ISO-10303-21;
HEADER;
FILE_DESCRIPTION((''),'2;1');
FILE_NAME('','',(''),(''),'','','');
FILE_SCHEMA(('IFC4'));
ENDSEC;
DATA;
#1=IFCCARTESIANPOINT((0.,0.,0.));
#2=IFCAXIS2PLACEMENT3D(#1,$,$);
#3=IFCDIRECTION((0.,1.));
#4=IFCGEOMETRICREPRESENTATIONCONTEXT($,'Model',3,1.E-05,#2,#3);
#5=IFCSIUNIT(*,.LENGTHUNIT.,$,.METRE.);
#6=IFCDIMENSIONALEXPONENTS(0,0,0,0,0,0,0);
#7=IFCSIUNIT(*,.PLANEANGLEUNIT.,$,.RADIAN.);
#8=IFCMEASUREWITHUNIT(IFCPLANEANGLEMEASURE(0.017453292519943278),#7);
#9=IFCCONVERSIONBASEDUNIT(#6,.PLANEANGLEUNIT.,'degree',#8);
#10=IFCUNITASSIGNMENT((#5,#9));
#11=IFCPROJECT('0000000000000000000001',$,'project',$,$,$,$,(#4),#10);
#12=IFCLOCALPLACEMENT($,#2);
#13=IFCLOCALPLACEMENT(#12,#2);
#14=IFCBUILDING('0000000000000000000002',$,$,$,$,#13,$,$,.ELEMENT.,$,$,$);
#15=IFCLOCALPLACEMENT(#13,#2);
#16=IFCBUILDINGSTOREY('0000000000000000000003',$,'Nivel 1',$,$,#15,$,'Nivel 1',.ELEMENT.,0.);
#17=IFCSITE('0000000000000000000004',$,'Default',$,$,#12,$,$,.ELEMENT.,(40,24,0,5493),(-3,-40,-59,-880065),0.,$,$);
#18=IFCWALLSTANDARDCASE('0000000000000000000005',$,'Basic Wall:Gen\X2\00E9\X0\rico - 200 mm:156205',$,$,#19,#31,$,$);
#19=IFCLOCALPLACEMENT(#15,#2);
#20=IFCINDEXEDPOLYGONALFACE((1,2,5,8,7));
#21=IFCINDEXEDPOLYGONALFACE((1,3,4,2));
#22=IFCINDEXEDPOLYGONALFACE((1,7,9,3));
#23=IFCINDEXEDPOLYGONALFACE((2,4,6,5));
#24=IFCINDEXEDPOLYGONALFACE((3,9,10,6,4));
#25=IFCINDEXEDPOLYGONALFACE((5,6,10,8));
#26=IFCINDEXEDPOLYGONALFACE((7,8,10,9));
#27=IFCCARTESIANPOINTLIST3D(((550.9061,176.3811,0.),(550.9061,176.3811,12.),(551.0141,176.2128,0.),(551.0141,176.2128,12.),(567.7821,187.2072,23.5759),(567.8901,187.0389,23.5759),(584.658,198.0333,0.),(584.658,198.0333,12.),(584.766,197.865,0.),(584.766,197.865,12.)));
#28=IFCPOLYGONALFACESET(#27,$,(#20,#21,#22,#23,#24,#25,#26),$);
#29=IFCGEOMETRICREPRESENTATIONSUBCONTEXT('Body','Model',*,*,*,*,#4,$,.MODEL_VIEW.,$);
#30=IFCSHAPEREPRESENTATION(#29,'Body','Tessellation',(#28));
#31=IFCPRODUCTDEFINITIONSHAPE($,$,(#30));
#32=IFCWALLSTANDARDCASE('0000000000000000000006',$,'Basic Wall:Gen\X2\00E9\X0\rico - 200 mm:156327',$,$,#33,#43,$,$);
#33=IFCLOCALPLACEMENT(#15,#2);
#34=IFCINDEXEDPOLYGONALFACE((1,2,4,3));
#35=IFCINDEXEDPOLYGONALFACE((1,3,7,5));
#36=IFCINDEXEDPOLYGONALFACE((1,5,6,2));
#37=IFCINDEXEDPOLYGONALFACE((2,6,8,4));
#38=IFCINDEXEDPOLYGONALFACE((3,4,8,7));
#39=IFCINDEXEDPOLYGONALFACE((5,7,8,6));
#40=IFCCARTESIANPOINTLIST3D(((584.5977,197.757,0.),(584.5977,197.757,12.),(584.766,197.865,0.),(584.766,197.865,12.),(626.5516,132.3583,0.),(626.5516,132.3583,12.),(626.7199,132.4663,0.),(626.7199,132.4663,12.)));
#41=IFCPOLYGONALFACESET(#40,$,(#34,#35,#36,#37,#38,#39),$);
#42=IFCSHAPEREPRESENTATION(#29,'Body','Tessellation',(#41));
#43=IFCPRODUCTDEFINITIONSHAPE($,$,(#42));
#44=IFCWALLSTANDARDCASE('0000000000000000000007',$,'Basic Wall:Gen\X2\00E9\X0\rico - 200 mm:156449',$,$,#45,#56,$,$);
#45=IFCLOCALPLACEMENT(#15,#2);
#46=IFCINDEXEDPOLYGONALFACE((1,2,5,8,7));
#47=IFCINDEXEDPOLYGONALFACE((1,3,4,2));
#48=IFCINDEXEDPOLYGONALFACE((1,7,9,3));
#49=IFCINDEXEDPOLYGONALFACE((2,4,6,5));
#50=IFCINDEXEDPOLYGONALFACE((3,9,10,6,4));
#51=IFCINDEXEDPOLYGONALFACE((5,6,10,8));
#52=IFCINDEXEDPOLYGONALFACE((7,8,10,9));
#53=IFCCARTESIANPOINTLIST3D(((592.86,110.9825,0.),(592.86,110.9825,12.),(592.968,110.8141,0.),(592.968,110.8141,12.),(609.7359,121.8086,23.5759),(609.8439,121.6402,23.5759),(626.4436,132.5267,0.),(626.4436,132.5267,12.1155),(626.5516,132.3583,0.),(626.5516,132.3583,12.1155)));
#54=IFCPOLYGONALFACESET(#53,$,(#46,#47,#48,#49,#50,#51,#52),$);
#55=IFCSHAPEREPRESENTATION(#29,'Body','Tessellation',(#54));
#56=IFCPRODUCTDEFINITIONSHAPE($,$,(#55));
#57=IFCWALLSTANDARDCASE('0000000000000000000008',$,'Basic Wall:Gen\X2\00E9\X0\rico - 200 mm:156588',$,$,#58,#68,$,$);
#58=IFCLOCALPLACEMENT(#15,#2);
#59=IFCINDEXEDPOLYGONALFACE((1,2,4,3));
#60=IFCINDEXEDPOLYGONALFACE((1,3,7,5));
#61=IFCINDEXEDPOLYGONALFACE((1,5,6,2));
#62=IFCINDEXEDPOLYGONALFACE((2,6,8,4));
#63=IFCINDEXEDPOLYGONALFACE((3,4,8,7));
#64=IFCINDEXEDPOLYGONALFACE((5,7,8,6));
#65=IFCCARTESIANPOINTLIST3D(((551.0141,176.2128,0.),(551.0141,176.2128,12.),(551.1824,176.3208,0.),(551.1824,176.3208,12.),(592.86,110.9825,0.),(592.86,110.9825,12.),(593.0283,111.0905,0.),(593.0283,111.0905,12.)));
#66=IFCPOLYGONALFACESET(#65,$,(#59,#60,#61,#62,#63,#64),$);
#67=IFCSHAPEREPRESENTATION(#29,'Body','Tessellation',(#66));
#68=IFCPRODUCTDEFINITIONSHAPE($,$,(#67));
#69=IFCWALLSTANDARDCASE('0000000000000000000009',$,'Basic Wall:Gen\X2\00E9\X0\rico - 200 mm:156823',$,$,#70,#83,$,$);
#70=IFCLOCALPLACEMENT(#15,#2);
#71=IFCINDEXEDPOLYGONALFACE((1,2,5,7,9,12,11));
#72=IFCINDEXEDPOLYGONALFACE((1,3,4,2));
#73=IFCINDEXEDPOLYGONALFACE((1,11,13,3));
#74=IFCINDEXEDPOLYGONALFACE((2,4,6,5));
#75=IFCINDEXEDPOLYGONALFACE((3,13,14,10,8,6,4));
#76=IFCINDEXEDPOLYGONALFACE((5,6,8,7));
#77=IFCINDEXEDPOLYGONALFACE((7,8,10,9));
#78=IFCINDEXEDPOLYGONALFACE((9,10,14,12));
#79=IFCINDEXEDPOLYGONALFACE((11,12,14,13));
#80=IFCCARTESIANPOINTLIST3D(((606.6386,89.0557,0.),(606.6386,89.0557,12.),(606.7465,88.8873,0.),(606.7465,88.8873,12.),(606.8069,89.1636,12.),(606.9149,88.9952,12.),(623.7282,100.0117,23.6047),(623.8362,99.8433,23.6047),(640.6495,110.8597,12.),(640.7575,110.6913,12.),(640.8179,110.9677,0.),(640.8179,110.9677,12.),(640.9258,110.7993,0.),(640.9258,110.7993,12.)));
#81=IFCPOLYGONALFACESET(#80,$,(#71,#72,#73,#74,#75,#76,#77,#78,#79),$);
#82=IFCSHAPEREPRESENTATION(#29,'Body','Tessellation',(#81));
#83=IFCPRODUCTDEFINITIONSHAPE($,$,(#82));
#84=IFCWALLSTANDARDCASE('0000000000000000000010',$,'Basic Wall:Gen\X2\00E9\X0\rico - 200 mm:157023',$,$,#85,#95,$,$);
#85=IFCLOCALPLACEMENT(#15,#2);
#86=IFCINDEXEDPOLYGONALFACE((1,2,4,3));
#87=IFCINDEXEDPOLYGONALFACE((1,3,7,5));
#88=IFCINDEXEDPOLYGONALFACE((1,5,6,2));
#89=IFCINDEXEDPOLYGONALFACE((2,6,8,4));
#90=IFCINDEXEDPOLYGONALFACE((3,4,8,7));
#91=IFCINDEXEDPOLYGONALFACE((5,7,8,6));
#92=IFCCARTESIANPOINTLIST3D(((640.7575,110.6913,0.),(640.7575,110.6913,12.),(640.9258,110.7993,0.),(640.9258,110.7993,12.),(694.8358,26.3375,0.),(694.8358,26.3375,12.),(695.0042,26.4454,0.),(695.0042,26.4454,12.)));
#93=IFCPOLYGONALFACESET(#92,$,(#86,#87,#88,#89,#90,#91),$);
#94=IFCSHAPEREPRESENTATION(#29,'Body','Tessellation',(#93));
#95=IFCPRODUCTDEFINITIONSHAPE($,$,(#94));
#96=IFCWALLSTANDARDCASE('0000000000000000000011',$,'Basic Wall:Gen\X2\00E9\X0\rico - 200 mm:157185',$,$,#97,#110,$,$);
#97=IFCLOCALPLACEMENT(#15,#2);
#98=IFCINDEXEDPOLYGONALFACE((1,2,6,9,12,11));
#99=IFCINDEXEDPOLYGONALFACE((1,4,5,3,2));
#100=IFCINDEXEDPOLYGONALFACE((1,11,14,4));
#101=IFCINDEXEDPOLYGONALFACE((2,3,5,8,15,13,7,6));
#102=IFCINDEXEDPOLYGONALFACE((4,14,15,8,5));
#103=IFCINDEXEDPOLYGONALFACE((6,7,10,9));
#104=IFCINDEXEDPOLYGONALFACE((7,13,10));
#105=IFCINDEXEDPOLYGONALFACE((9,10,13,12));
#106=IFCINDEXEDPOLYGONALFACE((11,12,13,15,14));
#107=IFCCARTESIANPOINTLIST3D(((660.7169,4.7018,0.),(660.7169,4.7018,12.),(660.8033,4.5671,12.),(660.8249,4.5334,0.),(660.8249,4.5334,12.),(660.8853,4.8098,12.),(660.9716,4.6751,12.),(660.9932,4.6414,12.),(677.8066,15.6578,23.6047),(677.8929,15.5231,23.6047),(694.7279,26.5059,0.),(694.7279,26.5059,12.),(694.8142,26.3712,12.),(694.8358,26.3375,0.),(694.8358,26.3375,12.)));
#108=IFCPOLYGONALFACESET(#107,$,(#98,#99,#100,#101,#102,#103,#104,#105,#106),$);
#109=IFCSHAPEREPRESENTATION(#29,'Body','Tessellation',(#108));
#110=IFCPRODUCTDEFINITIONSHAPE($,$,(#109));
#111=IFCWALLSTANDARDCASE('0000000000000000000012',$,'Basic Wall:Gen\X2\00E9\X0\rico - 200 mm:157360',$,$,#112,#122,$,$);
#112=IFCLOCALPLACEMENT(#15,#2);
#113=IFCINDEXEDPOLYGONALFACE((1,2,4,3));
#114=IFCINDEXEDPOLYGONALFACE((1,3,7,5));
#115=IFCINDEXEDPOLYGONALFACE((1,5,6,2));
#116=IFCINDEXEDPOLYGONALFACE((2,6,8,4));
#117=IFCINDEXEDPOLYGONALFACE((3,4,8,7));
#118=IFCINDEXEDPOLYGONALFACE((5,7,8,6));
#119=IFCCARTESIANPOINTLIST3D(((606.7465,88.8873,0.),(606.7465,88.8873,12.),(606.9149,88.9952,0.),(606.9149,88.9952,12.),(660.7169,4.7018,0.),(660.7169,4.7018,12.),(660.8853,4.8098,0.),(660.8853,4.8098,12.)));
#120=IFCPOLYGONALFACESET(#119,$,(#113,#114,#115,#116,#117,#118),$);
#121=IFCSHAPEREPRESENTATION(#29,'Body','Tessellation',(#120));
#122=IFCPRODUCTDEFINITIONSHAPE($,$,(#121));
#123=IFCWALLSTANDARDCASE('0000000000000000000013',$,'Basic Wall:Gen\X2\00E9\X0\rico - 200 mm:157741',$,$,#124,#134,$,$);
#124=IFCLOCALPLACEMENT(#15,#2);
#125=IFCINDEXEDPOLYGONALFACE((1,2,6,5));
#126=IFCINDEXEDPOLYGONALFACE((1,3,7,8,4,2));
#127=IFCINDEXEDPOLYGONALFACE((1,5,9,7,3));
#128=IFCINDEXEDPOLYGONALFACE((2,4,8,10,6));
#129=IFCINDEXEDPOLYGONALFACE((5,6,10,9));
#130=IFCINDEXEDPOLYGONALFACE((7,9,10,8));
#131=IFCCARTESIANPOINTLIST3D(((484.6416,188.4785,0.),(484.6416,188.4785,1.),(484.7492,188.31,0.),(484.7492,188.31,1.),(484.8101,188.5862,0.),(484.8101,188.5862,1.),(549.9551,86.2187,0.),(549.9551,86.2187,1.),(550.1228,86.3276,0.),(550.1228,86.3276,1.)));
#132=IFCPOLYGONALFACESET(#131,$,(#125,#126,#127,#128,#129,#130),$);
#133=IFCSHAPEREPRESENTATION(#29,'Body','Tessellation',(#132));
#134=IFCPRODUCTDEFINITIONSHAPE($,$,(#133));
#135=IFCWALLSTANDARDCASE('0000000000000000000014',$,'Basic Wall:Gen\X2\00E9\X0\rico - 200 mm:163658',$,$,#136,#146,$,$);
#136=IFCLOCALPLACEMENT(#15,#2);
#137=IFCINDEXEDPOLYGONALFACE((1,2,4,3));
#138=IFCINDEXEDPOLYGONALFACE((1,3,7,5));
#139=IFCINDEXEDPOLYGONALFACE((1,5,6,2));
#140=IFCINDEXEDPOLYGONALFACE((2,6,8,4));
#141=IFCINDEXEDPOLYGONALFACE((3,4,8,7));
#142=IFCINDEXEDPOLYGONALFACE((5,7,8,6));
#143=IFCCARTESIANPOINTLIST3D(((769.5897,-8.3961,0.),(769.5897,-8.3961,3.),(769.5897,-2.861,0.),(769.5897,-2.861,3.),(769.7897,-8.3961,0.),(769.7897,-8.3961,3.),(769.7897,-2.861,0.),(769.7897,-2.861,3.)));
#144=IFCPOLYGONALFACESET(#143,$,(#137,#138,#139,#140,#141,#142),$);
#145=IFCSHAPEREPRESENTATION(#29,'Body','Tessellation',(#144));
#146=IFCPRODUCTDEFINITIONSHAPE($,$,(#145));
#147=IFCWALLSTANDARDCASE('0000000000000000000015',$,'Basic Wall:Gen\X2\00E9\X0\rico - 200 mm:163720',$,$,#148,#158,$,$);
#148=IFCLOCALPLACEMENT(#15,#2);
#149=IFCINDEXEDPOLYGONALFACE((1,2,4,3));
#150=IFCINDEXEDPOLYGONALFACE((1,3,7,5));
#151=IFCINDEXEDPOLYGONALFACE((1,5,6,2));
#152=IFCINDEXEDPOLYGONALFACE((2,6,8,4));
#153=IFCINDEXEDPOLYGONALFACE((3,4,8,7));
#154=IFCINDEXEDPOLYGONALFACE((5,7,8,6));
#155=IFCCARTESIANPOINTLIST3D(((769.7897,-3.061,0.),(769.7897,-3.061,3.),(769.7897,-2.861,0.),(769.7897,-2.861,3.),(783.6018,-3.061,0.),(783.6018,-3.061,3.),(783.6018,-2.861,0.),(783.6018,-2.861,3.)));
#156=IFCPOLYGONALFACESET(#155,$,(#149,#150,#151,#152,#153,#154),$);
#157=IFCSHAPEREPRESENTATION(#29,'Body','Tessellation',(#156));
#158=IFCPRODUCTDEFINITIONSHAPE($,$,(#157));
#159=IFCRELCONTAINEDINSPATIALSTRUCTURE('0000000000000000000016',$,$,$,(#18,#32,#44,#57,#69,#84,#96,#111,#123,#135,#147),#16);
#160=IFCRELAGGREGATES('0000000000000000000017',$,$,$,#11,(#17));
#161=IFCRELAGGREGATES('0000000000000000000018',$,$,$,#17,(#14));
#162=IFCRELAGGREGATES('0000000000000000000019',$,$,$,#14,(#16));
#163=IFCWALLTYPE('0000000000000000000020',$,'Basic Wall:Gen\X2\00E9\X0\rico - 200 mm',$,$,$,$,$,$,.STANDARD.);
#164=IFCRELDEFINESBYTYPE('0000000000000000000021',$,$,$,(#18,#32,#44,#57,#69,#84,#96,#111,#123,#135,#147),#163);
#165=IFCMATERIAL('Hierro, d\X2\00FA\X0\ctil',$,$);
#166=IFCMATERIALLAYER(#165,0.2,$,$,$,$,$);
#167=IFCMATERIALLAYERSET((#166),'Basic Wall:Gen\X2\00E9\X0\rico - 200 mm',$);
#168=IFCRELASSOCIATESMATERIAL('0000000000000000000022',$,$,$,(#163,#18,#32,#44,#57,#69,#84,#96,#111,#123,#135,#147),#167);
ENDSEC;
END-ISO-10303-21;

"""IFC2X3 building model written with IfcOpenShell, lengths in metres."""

from ifc_helpers import new_model, entity, si_unit, converted_unit, direction, frame, frame_2d, origin, place, context, subcontext, project, spatial, polyline, rectangle, outline, extrude, clip, bounded_halfspace, material, layer, layer_set, layer_usage, type_object, element, save


model = new_model("IFC2X3")

# Units and contexts
model_context = context("Model", 3, precision=1e-05, world=origin(), true_north=direction((0.0, 1.0)))
body_context = subcontext(model_context, "Body", "Model", "MODEL_VIEW")
ifc_project = project(units=[si_unit("LENGTHUNIT", "METRE"), converted_unit("PLANEANGLEUNIT", "degree", entity("IfcPlaneAngleMeasure", 0.017453292519943278), si_unit("PLANEANGLEUNIT", "RADIAN"), dimensions=[0, 0, 0, 0, 0, 0, 0])], contexts=[model_context])

# Site, building, storey
site_placement = place(None, origin())
site = spatial("IfcSite", under=ifc_project, at=site_placement, Name="Default", CompositionType="ELEMENT", RefLatitude=(40, 24, 0, 5493), RefLongitude=(-3, -40, -59, -880065), RefElevation=0.0)
building_placement = place(site_placement, origin())
building = spatial("IfcBuilding", under=site, at=building_placement, CompositionType="ELEMENT")
storey_placement = place(building_placement, origin())
storey = spatial("IfcBuildingStorey", under=building, at=storey_placement, Name="Nivel 1", LongName="Nivel 1", CompositionType="ELEMENT", Elevation=0.0)

# Walls
ifc_material_1 = material(Name="Hierro, dúctil")
ifc_layer_1 = layer(ifc_material_1, 0.2)
ifc_layer_set_1 = layer_set([ifc_layer_1], Name="Basic Wall:Genérico - 200 mm")
ifc_layer_usage_1 = layer_usage(ifc_layer_set_1, "AXIS2", "NEGATIVE", 0.1)
wall_type = type_object("IfcWallType", Name="Basic Wall:Genérico - 200 mm", PredefinedType="STANDARD", material=ifc_layer_set_1)
wall_1_placement = place(storey_placement, frame((550.9601, 176.297, 0.0), z_axis=(0.0, 0.0, 1.0), x_axis=(0.841694, 0.539955, 0.0)))
element("IfcWallStandardCase", 1, at=wall_1_placement, inside=storey, type_object=wall_type, material=ifc_layer_usage_1, Name="Basic Wall:Genérico - 200 mm:156205", context=body_context, shape_type="Clipping", body=[
    clip(clip(extrude(rectangle(XDim=40.1, YDim=0.2, at=frame_2d((20.05, 0.0), x_axis=(-1.0, 0.0))), origin(), (0.0, 0.0, 1.0), 23.5759), bounded_halfspace(frame((20.05, -0.1, 23.5759), z_axis=(0.5, 0.0, 0.866025), x_axis=(0.0, 1.0, 0.0)), False, frame((20.05, -0.1, 23.5759)), polyline([(0.0, 0.0), (20.05, 0.0), (20.05, 0.2), (0.0, 0.2), (0.0, 0.0)]))), bounded_halfspace(frame((0.0, -0.1, 12.0), z_axis=(-0.5, 0.0, 0.866025), x_axis=(0.0, -1.0, 0.0)), False, frame((0.0, -0.1, 12.0)), polyline([(0.0, 0.0), (20.05, 0.0), (20.05, 0.2), (0.0, 0.2), (0.0, 0.0)]))),
])
ifc_layer_usage_2 = layer_usage(ifc_layer_set_1, "AXIS2", "NEGATIVE", 0.1)
wall_2_placement = place(storey_placement, frame((584.6819, 197.811, 0.0), z_axis=(0.0, 0.0, 1.0), x_axis=(0.539955, -0.841694, 0.0)))
element("IfcWallStandardCase", 2, at=wall_2_placement, inside=storey, type_object=wall_type, material=ifc_layer_usage_2, Name="Basic Wall:Genérico - 200 mm:156327", context=body_context, shape_type="SweptSolid", body=[
    extrude(rectangle(XDim=77.6989, YDim=0.2, at=frame_2d((38.8494, 0.0), x_axis=(-1.0, 0.0))), origin(), (0.0, 0.0, 1.0), 12.0),
])
ifc_layer_usage_3 = layer_usage(ifc_layer_set_1, "AXIS2", "NEGATIVE", 0.1)
wall_3_placement = place(storey_placement, frame((626.4976, 132.4425, 0.0), z_axis=(0.0, 0.0, 1.0), x_axis=(-0.841694, -0.539955, 0.0)))
element("IfcWallStandardCase", 3, at=wall_3_placement, inside=storey, type_object=wall_type, material=ifc_layer_usage_3, Name="Basic Wall:Genérico - 200 mm:156449", context=body_context, shape_type="Clipping", body=[
    clip(clip(extrude(rectangle(XDim=39.9, YDim=0.2, at=frame_2d((19.95, 0.0), x_axis=(-1.0, 0.0))), origin(), (0.0, 0.0, 1.0), 23.5759), bounded_halfspace(frame((0.0, -0.1, 12.1155), z_axis=(-0.5, 0.0, 0.866025), x_axis=(0.0, -1.0, 0.0)), False, frame((0.0, -0.1, 12.1155)), polyline([(0.0, 0.0), (19.85, 0.0), (19.85, 0.2), (0.0, 0.2), (0.0, 0.0)]))), bounded_halfspace(frame((19.85, -0.1, 23.5759), z_axis=(0.5, 0.0, 0.866025), x_axis=(0.0, 1.0, 0.0)), False, frame((19.85, -0.1, 23.5759)), polyline([(0.0, 0.0), (20.05, 0.0), (20.05, 0.2), (0.0, 0.2), (0.0, 0.0)]))),
])
ifc_layer_usage_4 = layer_usage(ifc_layer_set_1, "AXIS2", "NEGATIVE", 0.1)
wall_4_placement = place(storey_placement, frame((592.9441, 111.0365, 0.0), z_axis=(0.0, 0.0, 1.0), x_axis=(-0.539955, 0.841694, 0.0)))
element("IfcWallStandardCase", 4, at=wall_4_placement, inside=storey, type_object=wall_type, material=ifc_layer_usage_4, Name="Basic Wall:Genérico - 200 mm:156588", context=body_context, shape_type="SweptSolid", body=[
    extrude(rectangle(XDim=77.4989, YDim=0.2, at=frame_2d((38.7494, 0.0), x_axis=(-1.0, 0.0))), origin(), (0.0, 0.0, 1.0), 12.0),
])
ifc_layer_usage_5 = layer_usage(ifc_layer_set_1, "AXIS2", "NEGATIVE", 0.1)
wall_5_placement = place(storey_placement, frame((606.6925, 88.9715, 0.0), z_axis=(0.0, 0.0, 1.0), x_axis=(0.841855, 0.539704, 0.0)))
element("IfcWallStandardCase", 5, at=wall_5_placement, inside=storey, type_object=wall_type, material=ifc_layer_usage_5, Name="Basic Wall:Genérico - 200 mm:156823", context=body_context, shape_type="Clipping", body=[
    clip(clip(clip(clip(extrude(rectangle(XDim=40.6, YDim=0.2, at=frame_2d((20.3, 0.0), x_axis=(-1.0, 0.0))), origin(), (0.0, 0.0, 1.0), 23.6047), bounded_halfspace(frame((20.3, -0.1, 23.6047), z_axis=(0.5, 0.0, 0.866025), x_axis=(0.0, 1.0, 0.0)), False, frame((20.3, -0.1, 23.6047)), polyline([(0.0, 0.0), (20.1, 0.0), (20.1, 0.2), (0.0, 0.2), (0.0, 0.0)]))), bounded_halfspace(frame((0.2, -0.1, 12.0), z_axis=(-0.5, 0.0, 0.866025), x_axis=(0.0, -1.0, 0.0)), False, frame((0.2, -0.1, 12.0)), polyline([(0.0, 0.0), (20.1, 0.0), (20.1, 0.2), (0.0, 0.2), (0.0, 0.0)]))), bounded_halfspace(frame((40.4, -0.1, 12.0), z_axis=(0.0, 0.0, 1.0), x_axis=(0.0, 1.0, 0.0)), False, frame((40.4, -0.1, 12.0)), polyline([(0.0, 0.0), (0.2, 0.0), (0.2, 0.2), (0.0, 0.2), (0.0, 0.0)]))), bounded_halfspace(frame((0.0, -0.1, 12.0), z_axis=(0.0, 0.0, 1.0), x_axis=(0.0, 1.0, 0.0)), False, frame((0.0, -0.1, 12.0)), polyline([(0.0, 0.0), (0.2, 0.0), (0.2, 0.2), (0.0, 0.2), (0.0, 0.0)]))),
])
ifc_layer_usage_6 = layer_usage(ifc_layer_set_1, "AXIS2", "NEGATIVE", 0.1)
wall_6_placement = place(storey_placement, frame((640.8416, 110.7453, 0.0), z_axis=(0.0, 0.0, 1.0), x_axis=(0.539704, -0.841855, 0.0)))
element("IfcWallStandardCase", 6, at=wall_6_placement, inside=storey, type_object=wall_type, material=ifc_layer_usage_6, Name="Basic Wall:Genérico - 200 mm:157023", context=body_context, shape_type="SweptSolid", body=[
    extrude(rectangle(XDim=100.2, YDim=0.2, at=frame_2d((50.1, 0.0), x_axis=(-1.0, 0.0))), origin(), (0.0, 0.0, 1.0), 12.0),
])
ifc_layer_usage_7 = layer_usage(ifc_layer_set_1, "AXIS2", "NEGATIVE", 0.1)
wall_7_placement = place(storey_placement, frame((694.7818, 26.4217, 0.0), z_axis=(0.0, 0.0, 1.0), x_axis=(-0.841855, -0.539704, 0.0)))
element("IfcWallStandardCase", 7, at=wall_7_placement, inside=storey, type_object=wall_type, material=ifc_layer_usage_7, Name="Basic Wall:Genérico - 200 mm:157185", context=body_context, shape_type="Clipping", body=[
    clip(clip(clip(clip(clip(extrude(rectangle(XDim=40.4, YDim=0.2, at=frame_2d((20.2, 0.0), x_axis=(-1.0, 0.0))), origin(), (0.0, 0.0, 1.0), 23.6047), bounded_halfspace(frame((0.0, -0.1, 12.0), z_axis=(-0.5, 0.0, 0.866025), x_axis=(0.0, -1.0, 0.0)), False, frame((0.0, -0.1, 12.0)), polyline([(0.0, 0.0), (20.1, 0.0), (20.1, 0.16), (0.0, 0.16), (0.0, 0.0)]))), bounded_halfspace(frame((20.1, -0.1, 23.6047), z_axis=(0.5, 0.0, 0.866025), x_axis=(0.0, 1.0, 0.0)), False, frame((20.1, -0.1, 23.6047)), polyline([(0.0, 0.0), (20.1, 0.0), (20.1, 0.16), (0.0, 0.16), (0.0, 0.0)]))), bounded_halfspace(frame((40.2, -0.1, 12.0), z_axis=(0.0, 0.0, 1.0), x_axis=(0.0, 1.0, 0.0)), False, frame((40.2, -0.1, 12.0)), polyline([(0.0, 0.0), (0.2, 0.0), (0.2, 0.16), (0.0, 0.16), (0.0, 0.0)]))), bounded_halfspace(frame((40.2, 0.1, 12.0), z_axis=(0.0, 0.0, 1.0), x_axis=(0.0, 1.0, 0.0)), False, frame((40.2, 0.1, 12.0)), polyline([(0.0, 0.0), (-40.2, 0.0), (-40.2, -0.04), (0.0, -0.04), (0.0, 0.0)]))), bounded_halfspace(frame((40.4, 0.06, 12.0), z_axis=(0.0, 0.0, 1.0), x_axis=(0.0, 1.0, 0.0)), False, frame((40.4, 0.06, 12.0)), polyline([(0.0, 0.0), (0.0, 0.04), (-0.2, 0.04), (-0.2, 0.0), (0.0, 0.0)]))),
])
ifc_layer_usage_8 = layer_usage(ifc_layer_set_1, "AXIS2", "NEGATIVE", 0.1)
wall_8_placement = place(storey_placement, frame((660.8011, 4.7558, 0.0), z_axis=(0.0, 0.0, 1.0), x_axis=(-0.539704, 0.841855, 0.0)))
element("IfcWallStandardCase", 8, at=wall_8_placement, inside=storey, type_object=wall_type, material=ifc_layer_usage_8, Name="Basic Wall:Genérico - 200 mm:157360", context=body_context, shape_type="SweptSolid", body=[
    extrude(rectangle(XDim=100.0, YDim=0.2, at=frame_2d((50.0, 0.0), x_axis=(-1.0, 0.0))), origin(), (0.0, 0.0, 1.0), 12.0),
])
ifc_layer_usage_9 = layer_usage(ifc_layer_set_1, "AXIS2", "NEGATIVE", 0.1)
wall_9_placement = place(storey_placement, frame((550.0394, 86.2725, 0.0), z_axis=(0.0, 0.0, 1.0), x_axis=(-0.538277, 0.842768, 0.0)))
element("IfcWallStandardCase", 9, at=wall_9_placement, inside=storey, type_object=wall_type, material=ifc_layer_usage_9, Name="Basic Wall:Genérico - 200 mm:157741", context=body_context, shape_type="SweptSolid", body=[
    extrude(outline(polyline([(121.3381, -0.1), (121.3381, 0.1), (121.1381, 0.1), (0.0, 0.1), (0.0015, -0.1), (121.3381, -0.1)])), origin(), (0.0, 0.0, 1.0), 1.0),
])
ifc_layer_usage_10 = layer_usage(ifc_layer_set_1, "AXIS2", "NEGATIVE", 0.1)
wall_10_placement = place(storey_placement, frame((769.6897, -8.3961, 0.0), z_axis=(0.0, 0.0, 1.0), x_axis=(0.0, 1.0, 0.0)))
element("IfcWallStandardCase", 10, at=wall_10_placement, inside=storey, type_object=wall_type, material=ifc_layer_usage_10, Name="Basic Wall:Genérico - 200 mm:163658", context=body_context, shape_type="SweptSolid", body=[
    extrude(rectangle(XDim=5.5351, YDim=0.2, at=frame_2d((2.7675, 0.0), x_axis=(-1.0, 0.0))), origin(), (0.0, 0.0, 1.0), 3.0),
])
ifc_layer_usage_11 = layer_usage(ifc_layer_set_1, "AXIS2", "NEGATIVE", 0.1)
wall_11_placement = place(storey_placement, frame((769.7897, -2.961, 0.0)))
element("IfcWallStandardCase", 11, at=wall_11_placement, inside=storey, type_object=wall_type, material=ifc_layer_usage_11, Name="Basic Wall:Genérico - 200 mm:163720", context=body_context, shape_type="SweptSolid", body=[
    extrude(rectangle(XDim=13.8122, YDim=0.2, at=frame_2d((6.9061, 0.0), x_axis=(-1.0, 0.0))), origin(), (0.0, 0.0, 1.0), 3.0),
])

save(model, "model.ifc")
